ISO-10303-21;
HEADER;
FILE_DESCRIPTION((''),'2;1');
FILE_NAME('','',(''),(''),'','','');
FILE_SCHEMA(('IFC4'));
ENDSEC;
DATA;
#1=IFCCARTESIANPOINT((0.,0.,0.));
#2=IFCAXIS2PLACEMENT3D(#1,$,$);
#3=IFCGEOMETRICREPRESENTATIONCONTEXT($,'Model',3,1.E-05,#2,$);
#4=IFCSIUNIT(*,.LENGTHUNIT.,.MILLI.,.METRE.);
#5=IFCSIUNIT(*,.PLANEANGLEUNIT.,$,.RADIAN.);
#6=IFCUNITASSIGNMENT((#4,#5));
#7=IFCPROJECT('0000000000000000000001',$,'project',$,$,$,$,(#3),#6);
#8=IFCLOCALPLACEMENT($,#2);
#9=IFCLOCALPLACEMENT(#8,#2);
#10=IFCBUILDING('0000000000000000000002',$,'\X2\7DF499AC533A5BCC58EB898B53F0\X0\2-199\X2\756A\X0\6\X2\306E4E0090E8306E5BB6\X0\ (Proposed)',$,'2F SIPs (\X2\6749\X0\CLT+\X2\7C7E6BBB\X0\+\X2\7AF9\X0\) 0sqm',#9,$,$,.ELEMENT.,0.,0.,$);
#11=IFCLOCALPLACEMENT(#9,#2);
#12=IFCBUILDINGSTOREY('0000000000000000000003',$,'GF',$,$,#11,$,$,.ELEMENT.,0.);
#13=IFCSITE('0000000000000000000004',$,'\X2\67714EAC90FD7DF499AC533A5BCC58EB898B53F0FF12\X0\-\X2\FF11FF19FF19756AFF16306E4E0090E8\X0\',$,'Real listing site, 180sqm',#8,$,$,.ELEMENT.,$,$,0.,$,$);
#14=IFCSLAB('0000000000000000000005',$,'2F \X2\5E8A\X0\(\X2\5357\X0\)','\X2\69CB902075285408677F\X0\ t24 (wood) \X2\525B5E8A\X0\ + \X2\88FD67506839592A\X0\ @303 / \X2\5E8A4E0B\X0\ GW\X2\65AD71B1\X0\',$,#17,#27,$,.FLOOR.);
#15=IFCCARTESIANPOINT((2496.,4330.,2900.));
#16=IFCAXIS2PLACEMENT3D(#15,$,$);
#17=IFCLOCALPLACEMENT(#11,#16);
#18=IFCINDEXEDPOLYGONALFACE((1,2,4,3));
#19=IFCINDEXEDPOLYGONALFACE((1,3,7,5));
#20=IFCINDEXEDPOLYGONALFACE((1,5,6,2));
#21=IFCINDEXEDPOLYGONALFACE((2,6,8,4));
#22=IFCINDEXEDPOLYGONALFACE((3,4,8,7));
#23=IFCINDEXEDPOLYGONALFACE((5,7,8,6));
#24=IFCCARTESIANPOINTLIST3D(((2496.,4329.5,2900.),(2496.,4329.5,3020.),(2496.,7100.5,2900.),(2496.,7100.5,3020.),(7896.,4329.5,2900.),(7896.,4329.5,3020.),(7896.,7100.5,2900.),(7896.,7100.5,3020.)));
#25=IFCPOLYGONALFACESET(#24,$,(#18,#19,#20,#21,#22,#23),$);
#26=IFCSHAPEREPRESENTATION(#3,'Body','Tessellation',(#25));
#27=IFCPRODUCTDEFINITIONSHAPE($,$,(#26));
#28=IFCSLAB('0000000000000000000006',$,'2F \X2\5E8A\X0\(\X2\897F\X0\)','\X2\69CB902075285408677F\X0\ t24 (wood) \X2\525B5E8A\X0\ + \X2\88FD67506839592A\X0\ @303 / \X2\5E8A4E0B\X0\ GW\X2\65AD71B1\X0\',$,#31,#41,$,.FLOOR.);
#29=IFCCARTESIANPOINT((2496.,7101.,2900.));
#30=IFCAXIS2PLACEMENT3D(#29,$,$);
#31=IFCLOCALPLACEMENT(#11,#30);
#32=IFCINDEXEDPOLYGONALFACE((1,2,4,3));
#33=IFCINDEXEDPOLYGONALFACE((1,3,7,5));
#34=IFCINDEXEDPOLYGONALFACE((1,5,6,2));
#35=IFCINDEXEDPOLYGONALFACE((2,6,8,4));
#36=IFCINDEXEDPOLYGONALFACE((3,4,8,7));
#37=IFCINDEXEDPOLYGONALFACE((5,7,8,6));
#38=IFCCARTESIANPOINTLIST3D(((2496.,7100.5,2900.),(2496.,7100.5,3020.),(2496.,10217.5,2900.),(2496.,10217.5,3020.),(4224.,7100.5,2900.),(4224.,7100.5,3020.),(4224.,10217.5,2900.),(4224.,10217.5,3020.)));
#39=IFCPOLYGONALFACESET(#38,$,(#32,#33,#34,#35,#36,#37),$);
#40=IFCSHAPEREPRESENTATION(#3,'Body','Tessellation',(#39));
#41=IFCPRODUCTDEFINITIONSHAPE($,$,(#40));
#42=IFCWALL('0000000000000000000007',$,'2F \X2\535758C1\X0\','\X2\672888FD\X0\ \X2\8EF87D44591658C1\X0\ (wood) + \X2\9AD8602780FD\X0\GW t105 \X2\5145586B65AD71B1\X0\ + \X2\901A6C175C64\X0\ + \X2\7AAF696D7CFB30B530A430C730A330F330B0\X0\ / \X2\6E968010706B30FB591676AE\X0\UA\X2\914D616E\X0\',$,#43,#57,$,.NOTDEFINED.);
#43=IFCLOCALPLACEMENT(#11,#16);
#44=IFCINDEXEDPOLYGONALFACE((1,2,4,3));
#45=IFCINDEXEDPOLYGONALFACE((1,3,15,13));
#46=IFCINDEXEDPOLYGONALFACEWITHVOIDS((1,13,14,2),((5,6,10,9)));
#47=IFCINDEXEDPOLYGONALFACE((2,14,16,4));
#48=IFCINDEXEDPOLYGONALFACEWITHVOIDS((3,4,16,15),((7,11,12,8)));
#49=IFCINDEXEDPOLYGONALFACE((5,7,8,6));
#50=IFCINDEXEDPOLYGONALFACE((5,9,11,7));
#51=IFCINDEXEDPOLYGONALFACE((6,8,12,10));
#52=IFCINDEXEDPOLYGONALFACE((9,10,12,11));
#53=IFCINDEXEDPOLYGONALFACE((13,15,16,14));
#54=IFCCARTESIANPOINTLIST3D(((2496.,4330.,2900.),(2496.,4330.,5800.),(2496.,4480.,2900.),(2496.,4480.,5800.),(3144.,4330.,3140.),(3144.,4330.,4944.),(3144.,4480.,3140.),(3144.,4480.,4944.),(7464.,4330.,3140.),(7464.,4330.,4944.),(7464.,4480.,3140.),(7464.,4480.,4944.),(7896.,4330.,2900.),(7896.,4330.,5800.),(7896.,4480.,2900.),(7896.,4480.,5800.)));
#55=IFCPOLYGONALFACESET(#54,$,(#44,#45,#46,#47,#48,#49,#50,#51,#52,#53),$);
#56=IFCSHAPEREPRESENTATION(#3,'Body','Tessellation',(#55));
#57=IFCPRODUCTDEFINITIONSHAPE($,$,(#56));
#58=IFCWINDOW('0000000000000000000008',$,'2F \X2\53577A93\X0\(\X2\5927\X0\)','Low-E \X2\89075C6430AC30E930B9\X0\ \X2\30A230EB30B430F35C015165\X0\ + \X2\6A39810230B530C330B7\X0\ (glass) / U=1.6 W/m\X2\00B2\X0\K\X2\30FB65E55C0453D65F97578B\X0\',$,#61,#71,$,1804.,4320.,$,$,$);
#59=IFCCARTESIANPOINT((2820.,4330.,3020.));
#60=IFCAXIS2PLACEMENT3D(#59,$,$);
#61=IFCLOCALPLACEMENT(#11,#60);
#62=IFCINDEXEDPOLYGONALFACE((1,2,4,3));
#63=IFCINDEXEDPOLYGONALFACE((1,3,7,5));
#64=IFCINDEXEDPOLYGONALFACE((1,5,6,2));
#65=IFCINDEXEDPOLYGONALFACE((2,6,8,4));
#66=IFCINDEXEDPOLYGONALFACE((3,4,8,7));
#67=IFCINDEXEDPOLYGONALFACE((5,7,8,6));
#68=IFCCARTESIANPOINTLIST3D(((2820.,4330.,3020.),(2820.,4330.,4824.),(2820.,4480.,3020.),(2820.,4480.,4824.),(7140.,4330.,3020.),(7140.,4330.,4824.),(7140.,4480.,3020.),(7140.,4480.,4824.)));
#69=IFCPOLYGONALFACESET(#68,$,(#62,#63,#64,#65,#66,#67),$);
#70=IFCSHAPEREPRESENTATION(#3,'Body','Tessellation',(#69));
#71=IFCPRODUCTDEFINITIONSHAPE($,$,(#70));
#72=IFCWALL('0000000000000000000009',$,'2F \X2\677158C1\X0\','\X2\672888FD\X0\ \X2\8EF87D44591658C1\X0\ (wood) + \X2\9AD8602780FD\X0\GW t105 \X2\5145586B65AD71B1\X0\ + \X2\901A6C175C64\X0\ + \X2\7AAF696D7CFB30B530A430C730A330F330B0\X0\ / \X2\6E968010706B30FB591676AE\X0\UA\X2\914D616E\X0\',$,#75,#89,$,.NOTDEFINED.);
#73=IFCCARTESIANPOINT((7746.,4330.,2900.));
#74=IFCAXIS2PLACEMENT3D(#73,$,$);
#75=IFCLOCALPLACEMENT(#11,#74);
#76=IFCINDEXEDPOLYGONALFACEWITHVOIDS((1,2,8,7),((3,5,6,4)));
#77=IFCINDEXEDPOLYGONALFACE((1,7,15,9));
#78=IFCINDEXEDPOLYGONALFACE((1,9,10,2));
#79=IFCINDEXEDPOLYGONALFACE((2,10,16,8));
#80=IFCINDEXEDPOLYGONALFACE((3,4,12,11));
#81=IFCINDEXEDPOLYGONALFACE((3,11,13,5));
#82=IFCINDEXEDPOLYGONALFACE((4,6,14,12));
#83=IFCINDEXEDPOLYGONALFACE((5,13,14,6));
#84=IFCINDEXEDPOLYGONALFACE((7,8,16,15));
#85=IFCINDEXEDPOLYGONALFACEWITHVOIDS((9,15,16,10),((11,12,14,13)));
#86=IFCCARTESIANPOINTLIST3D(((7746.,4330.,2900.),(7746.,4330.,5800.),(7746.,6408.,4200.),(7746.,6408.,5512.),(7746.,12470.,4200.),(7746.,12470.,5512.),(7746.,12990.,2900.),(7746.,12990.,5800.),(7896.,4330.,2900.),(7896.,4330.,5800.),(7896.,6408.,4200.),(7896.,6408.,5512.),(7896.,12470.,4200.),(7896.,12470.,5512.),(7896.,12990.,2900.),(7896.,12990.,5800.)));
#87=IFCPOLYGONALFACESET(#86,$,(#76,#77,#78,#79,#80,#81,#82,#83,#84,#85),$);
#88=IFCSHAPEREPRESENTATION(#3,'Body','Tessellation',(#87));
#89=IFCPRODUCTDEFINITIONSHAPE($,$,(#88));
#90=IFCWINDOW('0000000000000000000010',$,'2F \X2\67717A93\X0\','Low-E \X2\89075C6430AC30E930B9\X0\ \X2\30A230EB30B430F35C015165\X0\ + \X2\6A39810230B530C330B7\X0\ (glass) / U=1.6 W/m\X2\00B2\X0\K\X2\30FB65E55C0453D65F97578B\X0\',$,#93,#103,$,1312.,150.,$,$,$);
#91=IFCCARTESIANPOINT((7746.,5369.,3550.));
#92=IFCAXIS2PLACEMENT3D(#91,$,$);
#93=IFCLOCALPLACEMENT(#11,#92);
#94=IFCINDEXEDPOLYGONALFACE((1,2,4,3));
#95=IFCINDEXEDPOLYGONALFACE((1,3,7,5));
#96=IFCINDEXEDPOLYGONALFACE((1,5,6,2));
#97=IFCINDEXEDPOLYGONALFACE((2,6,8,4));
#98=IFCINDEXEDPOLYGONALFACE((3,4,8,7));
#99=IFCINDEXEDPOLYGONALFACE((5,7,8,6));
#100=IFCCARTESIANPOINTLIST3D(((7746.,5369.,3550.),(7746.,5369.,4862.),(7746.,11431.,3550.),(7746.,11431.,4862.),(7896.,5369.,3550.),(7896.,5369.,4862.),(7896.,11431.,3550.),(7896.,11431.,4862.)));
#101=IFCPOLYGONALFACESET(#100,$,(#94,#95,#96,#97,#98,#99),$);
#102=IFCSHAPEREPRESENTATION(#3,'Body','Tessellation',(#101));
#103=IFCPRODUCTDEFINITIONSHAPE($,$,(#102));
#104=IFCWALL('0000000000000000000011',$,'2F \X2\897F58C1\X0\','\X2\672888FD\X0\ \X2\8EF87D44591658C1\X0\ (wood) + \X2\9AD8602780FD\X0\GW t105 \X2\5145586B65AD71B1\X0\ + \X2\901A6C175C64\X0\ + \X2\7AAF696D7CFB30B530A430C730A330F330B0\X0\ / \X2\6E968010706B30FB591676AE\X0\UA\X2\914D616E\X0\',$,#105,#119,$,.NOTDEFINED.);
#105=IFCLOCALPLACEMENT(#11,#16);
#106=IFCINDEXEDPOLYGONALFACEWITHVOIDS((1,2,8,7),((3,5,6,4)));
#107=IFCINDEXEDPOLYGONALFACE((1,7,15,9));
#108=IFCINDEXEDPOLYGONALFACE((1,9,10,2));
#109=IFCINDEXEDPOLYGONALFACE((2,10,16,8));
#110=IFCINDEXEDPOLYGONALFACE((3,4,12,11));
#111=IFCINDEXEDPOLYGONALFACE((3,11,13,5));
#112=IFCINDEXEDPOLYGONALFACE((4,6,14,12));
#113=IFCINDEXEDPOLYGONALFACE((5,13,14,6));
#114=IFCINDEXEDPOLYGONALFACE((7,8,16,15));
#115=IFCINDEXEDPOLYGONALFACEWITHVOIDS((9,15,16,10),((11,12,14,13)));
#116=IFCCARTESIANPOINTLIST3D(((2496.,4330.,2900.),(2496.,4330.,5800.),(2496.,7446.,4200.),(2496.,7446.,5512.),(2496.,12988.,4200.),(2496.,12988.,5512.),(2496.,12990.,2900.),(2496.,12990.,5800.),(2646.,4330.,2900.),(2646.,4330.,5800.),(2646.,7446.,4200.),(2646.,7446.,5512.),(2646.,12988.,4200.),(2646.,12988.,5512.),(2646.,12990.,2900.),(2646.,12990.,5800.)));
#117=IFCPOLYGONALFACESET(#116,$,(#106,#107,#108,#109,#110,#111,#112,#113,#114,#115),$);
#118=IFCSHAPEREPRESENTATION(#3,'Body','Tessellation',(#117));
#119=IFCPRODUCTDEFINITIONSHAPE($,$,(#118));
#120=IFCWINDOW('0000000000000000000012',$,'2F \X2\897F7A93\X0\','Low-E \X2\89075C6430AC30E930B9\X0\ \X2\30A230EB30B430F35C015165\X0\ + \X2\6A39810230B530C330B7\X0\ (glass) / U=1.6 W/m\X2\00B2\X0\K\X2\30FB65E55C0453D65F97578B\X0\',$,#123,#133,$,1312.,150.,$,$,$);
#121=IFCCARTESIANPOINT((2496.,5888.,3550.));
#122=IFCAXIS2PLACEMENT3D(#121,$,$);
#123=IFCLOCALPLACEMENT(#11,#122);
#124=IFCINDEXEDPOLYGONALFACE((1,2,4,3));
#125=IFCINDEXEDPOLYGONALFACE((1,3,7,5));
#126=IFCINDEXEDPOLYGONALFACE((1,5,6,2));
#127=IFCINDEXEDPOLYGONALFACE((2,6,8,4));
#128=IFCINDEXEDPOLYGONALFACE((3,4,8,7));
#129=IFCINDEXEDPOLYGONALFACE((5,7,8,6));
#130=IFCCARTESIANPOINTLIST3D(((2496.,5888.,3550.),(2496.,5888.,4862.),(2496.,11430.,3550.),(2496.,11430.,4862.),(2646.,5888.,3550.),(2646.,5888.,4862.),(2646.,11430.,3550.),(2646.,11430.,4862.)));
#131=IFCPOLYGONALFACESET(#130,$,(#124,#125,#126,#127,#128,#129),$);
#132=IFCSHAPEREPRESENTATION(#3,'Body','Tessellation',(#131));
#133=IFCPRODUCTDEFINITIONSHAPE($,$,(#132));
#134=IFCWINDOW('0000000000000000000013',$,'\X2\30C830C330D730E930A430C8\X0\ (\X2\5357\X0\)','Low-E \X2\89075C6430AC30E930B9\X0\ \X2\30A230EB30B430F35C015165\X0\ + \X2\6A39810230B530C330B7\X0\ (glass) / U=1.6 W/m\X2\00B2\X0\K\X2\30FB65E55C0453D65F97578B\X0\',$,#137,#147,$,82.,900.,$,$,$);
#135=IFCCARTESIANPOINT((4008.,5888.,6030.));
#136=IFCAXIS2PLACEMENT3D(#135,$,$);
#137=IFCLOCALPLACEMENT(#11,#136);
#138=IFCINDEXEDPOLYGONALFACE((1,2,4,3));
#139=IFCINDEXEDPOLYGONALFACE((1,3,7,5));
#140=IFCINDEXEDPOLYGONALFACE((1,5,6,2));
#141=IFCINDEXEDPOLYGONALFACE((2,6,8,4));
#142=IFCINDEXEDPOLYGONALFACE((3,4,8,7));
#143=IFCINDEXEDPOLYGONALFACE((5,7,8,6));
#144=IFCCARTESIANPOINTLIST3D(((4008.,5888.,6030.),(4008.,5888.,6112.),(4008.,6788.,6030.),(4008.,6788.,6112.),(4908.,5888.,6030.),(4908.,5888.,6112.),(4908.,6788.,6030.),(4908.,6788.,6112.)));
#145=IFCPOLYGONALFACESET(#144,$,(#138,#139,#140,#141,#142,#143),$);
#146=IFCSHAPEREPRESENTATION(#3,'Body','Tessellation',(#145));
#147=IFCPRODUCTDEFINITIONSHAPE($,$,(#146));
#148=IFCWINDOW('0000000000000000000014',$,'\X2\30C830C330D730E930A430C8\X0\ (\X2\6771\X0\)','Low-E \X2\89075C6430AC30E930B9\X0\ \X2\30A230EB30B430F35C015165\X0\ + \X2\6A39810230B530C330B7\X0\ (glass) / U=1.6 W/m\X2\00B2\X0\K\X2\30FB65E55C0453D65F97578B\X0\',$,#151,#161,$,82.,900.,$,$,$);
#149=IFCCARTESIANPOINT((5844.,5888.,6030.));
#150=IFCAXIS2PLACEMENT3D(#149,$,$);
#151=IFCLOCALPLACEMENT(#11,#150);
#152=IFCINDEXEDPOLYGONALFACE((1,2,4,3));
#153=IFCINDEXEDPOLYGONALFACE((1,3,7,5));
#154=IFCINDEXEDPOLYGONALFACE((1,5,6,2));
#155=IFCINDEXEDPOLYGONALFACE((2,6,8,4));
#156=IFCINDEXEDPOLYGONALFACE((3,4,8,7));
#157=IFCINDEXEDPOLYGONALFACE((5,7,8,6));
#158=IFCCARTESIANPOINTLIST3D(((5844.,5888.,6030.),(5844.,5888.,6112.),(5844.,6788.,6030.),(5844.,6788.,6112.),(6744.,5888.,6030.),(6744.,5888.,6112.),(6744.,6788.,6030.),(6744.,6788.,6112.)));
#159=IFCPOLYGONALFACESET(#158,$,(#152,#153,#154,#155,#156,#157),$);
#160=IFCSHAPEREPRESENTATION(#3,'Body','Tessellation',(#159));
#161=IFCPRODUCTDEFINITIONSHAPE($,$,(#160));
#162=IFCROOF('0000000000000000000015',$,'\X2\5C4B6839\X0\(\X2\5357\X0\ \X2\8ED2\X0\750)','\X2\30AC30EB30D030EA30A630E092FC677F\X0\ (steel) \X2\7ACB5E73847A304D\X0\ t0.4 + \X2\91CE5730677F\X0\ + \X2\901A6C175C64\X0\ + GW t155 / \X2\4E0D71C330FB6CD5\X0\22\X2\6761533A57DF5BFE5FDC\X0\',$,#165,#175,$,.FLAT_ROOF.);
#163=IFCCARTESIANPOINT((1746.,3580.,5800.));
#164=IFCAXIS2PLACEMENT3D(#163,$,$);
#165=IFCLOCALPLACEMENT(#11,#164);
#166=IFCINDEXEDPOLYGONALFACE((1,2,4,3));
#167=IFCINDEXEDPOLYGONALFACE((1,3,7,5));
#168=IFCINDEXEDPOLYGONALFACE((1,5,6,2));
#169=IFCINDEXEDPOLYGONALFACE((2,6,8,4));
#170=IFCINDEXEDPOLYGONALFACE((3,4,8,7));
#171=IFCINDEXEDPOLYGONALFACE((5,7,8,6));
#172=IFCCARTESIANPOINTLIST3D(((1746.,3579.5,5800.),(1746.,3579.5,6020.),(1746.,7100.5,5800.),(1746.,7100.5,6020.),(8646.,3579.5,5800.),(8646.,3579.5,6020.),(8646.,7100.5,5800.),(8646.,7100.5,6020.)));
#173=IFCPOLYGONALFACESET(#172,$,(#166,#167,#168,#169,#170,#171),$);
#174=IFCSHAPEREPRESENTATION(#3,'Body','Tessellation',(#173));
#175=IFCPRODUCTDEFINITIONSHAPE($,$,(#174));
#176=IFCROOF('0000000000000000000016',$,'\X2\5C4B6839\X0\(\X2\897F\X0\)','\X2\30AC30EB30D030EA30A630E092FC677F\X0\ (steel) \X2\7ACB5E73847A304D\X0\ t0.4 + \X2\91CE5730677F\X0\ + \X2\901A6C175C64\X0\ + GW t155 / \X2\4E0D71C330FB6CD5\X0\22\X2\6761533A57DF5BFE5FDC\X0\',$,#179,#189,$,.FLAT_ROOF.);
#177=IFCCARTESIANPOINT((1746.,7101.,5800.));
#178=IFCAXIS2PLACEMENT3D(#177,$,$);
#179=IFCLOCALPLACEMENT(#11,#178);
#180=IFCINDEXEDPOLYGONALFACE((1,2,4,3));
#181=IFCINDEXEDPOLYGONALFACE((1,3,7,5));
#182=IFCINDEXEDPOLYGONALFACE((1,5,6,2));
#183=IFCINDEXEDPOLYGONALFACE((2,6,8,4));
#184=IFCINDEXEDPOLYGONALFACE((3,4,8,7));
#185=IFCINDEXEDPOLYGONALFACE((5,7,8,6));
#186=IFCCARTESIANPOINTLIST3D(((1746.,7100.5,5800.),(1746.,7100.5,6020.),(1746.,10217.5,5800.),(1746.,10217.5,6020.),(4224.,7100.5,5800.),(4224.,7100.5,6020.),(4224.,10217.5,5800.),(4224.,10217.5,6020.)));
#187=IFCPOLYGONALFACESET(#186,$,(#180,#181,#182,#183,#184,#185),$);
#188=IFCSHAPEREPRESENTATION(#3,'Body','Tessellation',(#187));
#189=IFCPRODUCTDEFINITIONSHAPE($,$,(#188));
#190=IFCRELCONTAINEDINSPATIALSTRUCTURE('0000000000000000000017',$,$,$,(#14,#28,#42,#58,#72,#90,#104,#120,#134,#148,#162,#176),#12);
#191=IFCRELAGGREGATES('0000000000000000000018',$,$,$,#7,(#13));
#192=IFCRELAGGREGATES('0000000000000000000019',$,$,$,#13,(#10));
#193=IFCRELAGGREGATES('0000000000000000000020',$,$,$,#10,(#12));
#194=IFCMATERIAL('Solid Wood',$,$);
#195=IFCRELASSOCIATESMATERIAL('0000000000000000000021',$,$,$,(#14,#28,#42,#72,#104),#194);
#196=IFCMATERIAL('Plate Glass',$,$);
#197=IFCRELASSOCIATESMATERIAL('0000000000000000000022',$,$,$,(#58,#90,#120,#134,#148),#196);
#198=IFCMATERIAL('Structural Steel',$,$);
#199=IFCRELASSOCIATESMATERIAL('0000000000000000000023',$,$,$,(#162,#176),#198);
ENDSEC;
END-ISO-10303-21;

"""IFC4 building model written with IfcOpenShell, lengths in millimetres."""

from ifc_helpers import new_model, si_unit, frame, frame_2d, origin, place, context, project, spatial, rectangle, extrude, material, element, fill, save


model = new_model("IFC4")

# Units and contexts
model_context = context("Model", 3, precision=1e-05, world=origin())
ifc_project = project(units=[si_unit("LENGTHUNIT", "METRE", prefix="MILLI"), si_unit("PLANEANGLEUNIT", "RADIAN")], contexts=[model_context])

# Site, building, storey
site_placement = place(None, origin())
site = spatial("IfcSite", under=ifc_project, at=site_placement, Name="東京都練馬区富士見台２-１９９番６の一部", ObjectType="Real listing site, 180sqm", CompositionType="ELEMENT", RefElevation=0.0)
building_placement = place(site_placement, origin())
building = spatial("IfcBuilding", under=site, at=building_placement, Name="練馬区富士見台2-199番6の一部の家 (Proposed)", ObjectType="2F SIPs (杉CLT+籾殻+竹) 0sqm", CompositionType="ELEMENT", ElevationOfRefHeight=0.0, ElevationOfTerrain=0.0)
storey_placement = place(building_placement, origin())
storey = spatial("IfcBuildingStorey", under=building, at=storey_placement, Name="GF", CompositionType="ELEMENT", Elevation=0.0)

# Slabs
ifc_material_1 = material(Name="Solid Wood")
slab_1_placement = place(storey_placement, frame((2496.0, 4330.0, 2900.0)))
element("IfcSlab", 1, at=slab_1_placement, inside=storey, material=ifc_material_1, Name="2F 床(南)", Description="構造用合板 t24 (wood) 剛床 + 製材根太 @303 / 床下 GW断熱", PredefinedType="FLOOR", context=model_context, shape_type="SweptSolid", body=[
    extrude(rectangle(XDim=5400.0, YDim=2771.0, at=frame_2d((2700.0, 1385.0))), frame((2496.0, 4330.0, 2900.0)), (0.0, 0.0, 1.0), 120.0),
])
slab_2_placement = place(storey_placement, frame((2496.0, 7101.0, 2900.0)))
element("IfcSlab", 2, at=slab_2_placement, inside=storey, material=ifc_material_1, Name="2F 床(西)", Description="構造用合板 t24 (wood) 剛床 + 製材根太 @303 / 床下 GW断熱", PredefinedType="FLOOR", context=model_context, shape_type="SweptSolid", body=[
    extrude(rectangle(XDim=1728.0, YDim=3117.0, at=frame_2d((864.0, 1558.0))), frame((2496.0, 7101.0, 2900.0)), (0.0, 0.0, 1.0), 120.0),
])

# Walls, openings, windows
wall_1_placement = place(storey_placement, frame((2496.0, 4330.0, 2900.0)))
wall_1 = element("IfcWall", 3, at=wall_1_placement, inside=storey, material=ifc_material_1, Name="2F 南壁", Description="木製 軸組外壁 (wood) + 高性能GW t105 充填断熱 + 通気層 + 窯業系サイディング / 準耐火・外皮UA配慮", PredefinedType="NOTDEFINED", context=model_context, shape_type="SweptSolid", body=[
    extrude(rectangle(XDim=5400.0, YDim=150.0, at=frame_2d((2700.0, 75.0))), frame((2496.0, 4330.0, 2900.0)), (0.0, 0.0, 1.0), 2900.0),
])
opening_1_placement = place(storey_placement, frame((2820.0, 4330.0, 3020.0)))
opening_1 = element("IfcOpeningElement", 4, at=opening_1_placement, cuts=wall_1, PredefinedType="NOTDEFINED", context=model_context, shape_type="SweptSolid", body=[
    extrude(rectangle(XDim=4320.0, YDim=150.0, at=frame_2d((2160.0, 75.0))), frame((2820.0, 4330.0, 3020.0)), (0.0, 0.0, 1.0), 1804.0),
])
ifc_material_2 = material(Name="Plate Glass")
window_1_placement = place(storey_placement, frame((2820.0, 4330.0, 3020.0)))
window_1 = element("IfcWindow", 5, at=window_1_placement, inside=storey, material=ifc_material_2, Name="2F 南窓(大)", Description="Low-E 複層ガラス アルゴン封入 + 樹脂サッシ (glass) / U=1.6 W/m²K・日射取得型", OverallHeight=1804.0, OverallWidth=4320.0, context=model_context, shape_type="SweptSolid", body=[
    extrude(rectangle(XDim=4320.0, YDim=150.0, at=frame_2d((2160.0, 75.0))), frame((2820.0, 4330.0, 3020.0)), (0.0, 0.0, 1.0), 1804.0),
])
fill(opening_1, window_1)
wall_2_placement = place(storey_placement, frame((7746.0, 4330.0, 2900.0)))
wall_2 = element("IfcWall", 6, at=wall_2_placement, inside=storey, material=ifc_material_1, Name="2F 東壁", Description="木製 軸組外壁 (wood) + 高性能GW t105 充填断熱 + 通気層 + 窯業系サイディング / 準耐火・外皮UA配慮", PredefinedType="NOTDEFINED", context=model_context, shape_type="SweptSolid", body=[
    extrude(rectangle(XDim=150.0, YDim=8660.0, at=frame_2d((75.0, 4330.0))), frame((7746.0, 4330.0, 2900.0)), (0.0, 0.0, 1.0), 2900.0),
])
opening_2_placement = place(storey_placement, frame((7746.0, 5369.0, 3550.0)))
opening_2 = element("IfcOpeningElement", 7, at=opening_2_placement, cuts=wall_2, PredefinedType="NOTDEFINED", context=model_context, shape_type="SweptSolid", body=[
    extrude(rectangle(XDim=150.0, YDim=6062.0, at=frame_2d((75.0, 3031.0))), frame((7746.0, 5369.0, 3550.0)), (0.0, 0.0, 1.0), 1312.0),
])
window_2_placement = place(storey_placement, frame((7746.0, 5369.0, 3550.0)))
window_2 = element("IfcWindow", 8, at=window_2_placement, inside=storey, material=ifc_material_2, Name="2F 東窓", Description="Low-E 複層ガラス アルゴン封入 + 樹脂サッシ (glass) / U=1.6 W/m²K・日射取得型", OverallHeight=1312.0, OverallWidth=150.0, context=model_context, shape_type="SweptSolid", body=[
    extrude(rectangle(XDim=150.0, YDim=6062.0, at=frame_2d((75.0, 3031.0))), frame((7746.0, 5369.0, 3550.0)), (0.0, 0.0, 1.0), 1312.0),
])
fill(opening_2, window_2)
wall_3_placement = place(storey_placement, frame((2496.0, 4330.0, 2900.0)))
wall_3 = element("IfcWall", 9, at=wall_3_placement, inside=storey, material=ifc_material_1, Name="2F 西壁", Description="木製 軸組外壁 (wood) + 高性能GW t105 充填断熱 + 通気層 + 窯業系サイディング / 準耐火・外皮UA配慮", PredefinedType="NOTDEFINED", context=model_context, shape_type="SweptSolid", body=[
    extrude(rectangle(XDim=150.0, YDim=8660.0, at=frame_2d((75.0, 4330.0))), frame((2496.0, 4330.0, 2900.0)), (0.0, 0.0, 1.0), 2900.0),
])
opening_3_placement = place(storey_placement, frame((2496.0, 5888.0, 3550.0)))
opening_3 = element("IfcOpeningElement", 10, at=opening_3_placement, cuts=wall_3, PredefinedType="NOTDEFINED", context=model_context, shape_type="SweptSolid", body=[
    extrude(rectangle(XDim=150.0, YDim=5542.0, at=frame_2d((75.0, 2771.0))), frame((2496.0, 5888.0, 3550.0)), (0.0, 0.0, 1.0), 1312.0),
])
window_3_placement = place(storey_placement, frame((2496.0, 5888.0, 3550.0)))
window_3 = element("IfcWindow", 11, at=window_3_placement, inside=storey, material=ifc_material_2, Name="2F 西窓", Description="Low-E 複層ガラス アルゴン封入 + 樹脂サッシ (glass) / U=1.6 W/m²K・日射取得型", OverallHeight=1312.0, OverallWidth=150.0, context=model_context, shape_type="SweptSolid", body=[
    extrude(rectangle(XDim=150.0, YDim=5542.0, at=frame_2d((75.0, 2771.0))), frame((2496.0, 5888.0, 3550.0)), (0.0, 0.0, 1.0), 1312.0),
])
fill(opening_3, window_3)

# Windows
window_4_placement = place(storey_placement, frame((4008.0, 5888.0, 6030.0)))
element("IfcWindow", 12, at=window_4_placement, inside=storey, material=ifc_material_2, Name="トップライト (南)", Description="Low-E 複層ガラス アルゴン封入 + 樹脂サッシ (glass) / U=1.6 W/m²K・日射取得型", OverallHeight=82.0, OverallWidth=900.0, context=model_context, shape_type="SweptSolid", body=[
    extrude(rectangle(XDim=900.0, YDim=900.0, at=frame_2d((450.0, 450.0))), frame((4008.0, 5888.0, 6030.0)), (0.0, 0.0, 1.0), 82.0),
])
window_5_placement = place(storey_placement, frame((5844.0, 5888.0, 6030.0)))
element("IfcWindow", 13, at=window_5_placement, inside=storey, material=ifc_material_2, Name="トップライト (東)", Description="Low-E 複層ガラス アルゴン封入 + 樹脂サッシ (glass) / U=1.6 W/m²K・日射取得型", OverallHeight=82.0, OverallWidth=900.0, context=model_context, shape_type="SweptSolid", body=[
    extrude(rectangle(XDim=900.0, YDim=900.0, at=frame_2d((450.0, 450.0))), frame((5844.0, 5888.0, 6030.0)), (0.0, 0.0, 1.0), 82.0),
])

# Roofs
ifc_material_3 = material(Name="Structural Steel")
roof_1_placement = place(storey_placement, frame((1746.0, 3580.0, 5800.0)))
element("IfcRoof", 14, at=roof_1_placement, inside=storey, material=ifc_material_3, Name="屋根(南 軒750)", Description="ガルバリウム鋼板 (steel) 立平葺き t0.4 + 野地板 + 通気層 + GW t155 / 不燃・法22条区域対応", PredefinedType="FLAT_ROOF", context=model_context, shape_type="SweptSolid", body=[
    extrude(rectangle(XDim=6900.0, YDim=3521.0, at=frame_2d((3450.0, 1760.0))), frame((1746.0, 3580.0, 5800.0)), (0.0, 0.0, 1.0), 220.0),
])
roof_2_placement = place(storey_placement, frame((1746.0, 7101.0, 5800.0)))
element("IfcRoof", 15, at=roof_2_placement, inside=storey, material=ifc_material_3, Name="屋根(西)", Description="ガルバリウム鋼板 (steel) 立平葺き t0.4 + 野地板 + 通気層 + GW t155 / 不燃・法22条区域対応", PredefinedType="FLAT_ROOF", context=model_context, shape_type="SweptSolid", body=[
    extrude(rectangle(XDim=2478.0, YDim=3117.0, at=frame_2d((1239.0, 1558.0))), frame((1746.0, 7101.0, 5800.0)), (0.0, 0.0, 1.0), 220.0),
])

save(model, "model.ifc")
